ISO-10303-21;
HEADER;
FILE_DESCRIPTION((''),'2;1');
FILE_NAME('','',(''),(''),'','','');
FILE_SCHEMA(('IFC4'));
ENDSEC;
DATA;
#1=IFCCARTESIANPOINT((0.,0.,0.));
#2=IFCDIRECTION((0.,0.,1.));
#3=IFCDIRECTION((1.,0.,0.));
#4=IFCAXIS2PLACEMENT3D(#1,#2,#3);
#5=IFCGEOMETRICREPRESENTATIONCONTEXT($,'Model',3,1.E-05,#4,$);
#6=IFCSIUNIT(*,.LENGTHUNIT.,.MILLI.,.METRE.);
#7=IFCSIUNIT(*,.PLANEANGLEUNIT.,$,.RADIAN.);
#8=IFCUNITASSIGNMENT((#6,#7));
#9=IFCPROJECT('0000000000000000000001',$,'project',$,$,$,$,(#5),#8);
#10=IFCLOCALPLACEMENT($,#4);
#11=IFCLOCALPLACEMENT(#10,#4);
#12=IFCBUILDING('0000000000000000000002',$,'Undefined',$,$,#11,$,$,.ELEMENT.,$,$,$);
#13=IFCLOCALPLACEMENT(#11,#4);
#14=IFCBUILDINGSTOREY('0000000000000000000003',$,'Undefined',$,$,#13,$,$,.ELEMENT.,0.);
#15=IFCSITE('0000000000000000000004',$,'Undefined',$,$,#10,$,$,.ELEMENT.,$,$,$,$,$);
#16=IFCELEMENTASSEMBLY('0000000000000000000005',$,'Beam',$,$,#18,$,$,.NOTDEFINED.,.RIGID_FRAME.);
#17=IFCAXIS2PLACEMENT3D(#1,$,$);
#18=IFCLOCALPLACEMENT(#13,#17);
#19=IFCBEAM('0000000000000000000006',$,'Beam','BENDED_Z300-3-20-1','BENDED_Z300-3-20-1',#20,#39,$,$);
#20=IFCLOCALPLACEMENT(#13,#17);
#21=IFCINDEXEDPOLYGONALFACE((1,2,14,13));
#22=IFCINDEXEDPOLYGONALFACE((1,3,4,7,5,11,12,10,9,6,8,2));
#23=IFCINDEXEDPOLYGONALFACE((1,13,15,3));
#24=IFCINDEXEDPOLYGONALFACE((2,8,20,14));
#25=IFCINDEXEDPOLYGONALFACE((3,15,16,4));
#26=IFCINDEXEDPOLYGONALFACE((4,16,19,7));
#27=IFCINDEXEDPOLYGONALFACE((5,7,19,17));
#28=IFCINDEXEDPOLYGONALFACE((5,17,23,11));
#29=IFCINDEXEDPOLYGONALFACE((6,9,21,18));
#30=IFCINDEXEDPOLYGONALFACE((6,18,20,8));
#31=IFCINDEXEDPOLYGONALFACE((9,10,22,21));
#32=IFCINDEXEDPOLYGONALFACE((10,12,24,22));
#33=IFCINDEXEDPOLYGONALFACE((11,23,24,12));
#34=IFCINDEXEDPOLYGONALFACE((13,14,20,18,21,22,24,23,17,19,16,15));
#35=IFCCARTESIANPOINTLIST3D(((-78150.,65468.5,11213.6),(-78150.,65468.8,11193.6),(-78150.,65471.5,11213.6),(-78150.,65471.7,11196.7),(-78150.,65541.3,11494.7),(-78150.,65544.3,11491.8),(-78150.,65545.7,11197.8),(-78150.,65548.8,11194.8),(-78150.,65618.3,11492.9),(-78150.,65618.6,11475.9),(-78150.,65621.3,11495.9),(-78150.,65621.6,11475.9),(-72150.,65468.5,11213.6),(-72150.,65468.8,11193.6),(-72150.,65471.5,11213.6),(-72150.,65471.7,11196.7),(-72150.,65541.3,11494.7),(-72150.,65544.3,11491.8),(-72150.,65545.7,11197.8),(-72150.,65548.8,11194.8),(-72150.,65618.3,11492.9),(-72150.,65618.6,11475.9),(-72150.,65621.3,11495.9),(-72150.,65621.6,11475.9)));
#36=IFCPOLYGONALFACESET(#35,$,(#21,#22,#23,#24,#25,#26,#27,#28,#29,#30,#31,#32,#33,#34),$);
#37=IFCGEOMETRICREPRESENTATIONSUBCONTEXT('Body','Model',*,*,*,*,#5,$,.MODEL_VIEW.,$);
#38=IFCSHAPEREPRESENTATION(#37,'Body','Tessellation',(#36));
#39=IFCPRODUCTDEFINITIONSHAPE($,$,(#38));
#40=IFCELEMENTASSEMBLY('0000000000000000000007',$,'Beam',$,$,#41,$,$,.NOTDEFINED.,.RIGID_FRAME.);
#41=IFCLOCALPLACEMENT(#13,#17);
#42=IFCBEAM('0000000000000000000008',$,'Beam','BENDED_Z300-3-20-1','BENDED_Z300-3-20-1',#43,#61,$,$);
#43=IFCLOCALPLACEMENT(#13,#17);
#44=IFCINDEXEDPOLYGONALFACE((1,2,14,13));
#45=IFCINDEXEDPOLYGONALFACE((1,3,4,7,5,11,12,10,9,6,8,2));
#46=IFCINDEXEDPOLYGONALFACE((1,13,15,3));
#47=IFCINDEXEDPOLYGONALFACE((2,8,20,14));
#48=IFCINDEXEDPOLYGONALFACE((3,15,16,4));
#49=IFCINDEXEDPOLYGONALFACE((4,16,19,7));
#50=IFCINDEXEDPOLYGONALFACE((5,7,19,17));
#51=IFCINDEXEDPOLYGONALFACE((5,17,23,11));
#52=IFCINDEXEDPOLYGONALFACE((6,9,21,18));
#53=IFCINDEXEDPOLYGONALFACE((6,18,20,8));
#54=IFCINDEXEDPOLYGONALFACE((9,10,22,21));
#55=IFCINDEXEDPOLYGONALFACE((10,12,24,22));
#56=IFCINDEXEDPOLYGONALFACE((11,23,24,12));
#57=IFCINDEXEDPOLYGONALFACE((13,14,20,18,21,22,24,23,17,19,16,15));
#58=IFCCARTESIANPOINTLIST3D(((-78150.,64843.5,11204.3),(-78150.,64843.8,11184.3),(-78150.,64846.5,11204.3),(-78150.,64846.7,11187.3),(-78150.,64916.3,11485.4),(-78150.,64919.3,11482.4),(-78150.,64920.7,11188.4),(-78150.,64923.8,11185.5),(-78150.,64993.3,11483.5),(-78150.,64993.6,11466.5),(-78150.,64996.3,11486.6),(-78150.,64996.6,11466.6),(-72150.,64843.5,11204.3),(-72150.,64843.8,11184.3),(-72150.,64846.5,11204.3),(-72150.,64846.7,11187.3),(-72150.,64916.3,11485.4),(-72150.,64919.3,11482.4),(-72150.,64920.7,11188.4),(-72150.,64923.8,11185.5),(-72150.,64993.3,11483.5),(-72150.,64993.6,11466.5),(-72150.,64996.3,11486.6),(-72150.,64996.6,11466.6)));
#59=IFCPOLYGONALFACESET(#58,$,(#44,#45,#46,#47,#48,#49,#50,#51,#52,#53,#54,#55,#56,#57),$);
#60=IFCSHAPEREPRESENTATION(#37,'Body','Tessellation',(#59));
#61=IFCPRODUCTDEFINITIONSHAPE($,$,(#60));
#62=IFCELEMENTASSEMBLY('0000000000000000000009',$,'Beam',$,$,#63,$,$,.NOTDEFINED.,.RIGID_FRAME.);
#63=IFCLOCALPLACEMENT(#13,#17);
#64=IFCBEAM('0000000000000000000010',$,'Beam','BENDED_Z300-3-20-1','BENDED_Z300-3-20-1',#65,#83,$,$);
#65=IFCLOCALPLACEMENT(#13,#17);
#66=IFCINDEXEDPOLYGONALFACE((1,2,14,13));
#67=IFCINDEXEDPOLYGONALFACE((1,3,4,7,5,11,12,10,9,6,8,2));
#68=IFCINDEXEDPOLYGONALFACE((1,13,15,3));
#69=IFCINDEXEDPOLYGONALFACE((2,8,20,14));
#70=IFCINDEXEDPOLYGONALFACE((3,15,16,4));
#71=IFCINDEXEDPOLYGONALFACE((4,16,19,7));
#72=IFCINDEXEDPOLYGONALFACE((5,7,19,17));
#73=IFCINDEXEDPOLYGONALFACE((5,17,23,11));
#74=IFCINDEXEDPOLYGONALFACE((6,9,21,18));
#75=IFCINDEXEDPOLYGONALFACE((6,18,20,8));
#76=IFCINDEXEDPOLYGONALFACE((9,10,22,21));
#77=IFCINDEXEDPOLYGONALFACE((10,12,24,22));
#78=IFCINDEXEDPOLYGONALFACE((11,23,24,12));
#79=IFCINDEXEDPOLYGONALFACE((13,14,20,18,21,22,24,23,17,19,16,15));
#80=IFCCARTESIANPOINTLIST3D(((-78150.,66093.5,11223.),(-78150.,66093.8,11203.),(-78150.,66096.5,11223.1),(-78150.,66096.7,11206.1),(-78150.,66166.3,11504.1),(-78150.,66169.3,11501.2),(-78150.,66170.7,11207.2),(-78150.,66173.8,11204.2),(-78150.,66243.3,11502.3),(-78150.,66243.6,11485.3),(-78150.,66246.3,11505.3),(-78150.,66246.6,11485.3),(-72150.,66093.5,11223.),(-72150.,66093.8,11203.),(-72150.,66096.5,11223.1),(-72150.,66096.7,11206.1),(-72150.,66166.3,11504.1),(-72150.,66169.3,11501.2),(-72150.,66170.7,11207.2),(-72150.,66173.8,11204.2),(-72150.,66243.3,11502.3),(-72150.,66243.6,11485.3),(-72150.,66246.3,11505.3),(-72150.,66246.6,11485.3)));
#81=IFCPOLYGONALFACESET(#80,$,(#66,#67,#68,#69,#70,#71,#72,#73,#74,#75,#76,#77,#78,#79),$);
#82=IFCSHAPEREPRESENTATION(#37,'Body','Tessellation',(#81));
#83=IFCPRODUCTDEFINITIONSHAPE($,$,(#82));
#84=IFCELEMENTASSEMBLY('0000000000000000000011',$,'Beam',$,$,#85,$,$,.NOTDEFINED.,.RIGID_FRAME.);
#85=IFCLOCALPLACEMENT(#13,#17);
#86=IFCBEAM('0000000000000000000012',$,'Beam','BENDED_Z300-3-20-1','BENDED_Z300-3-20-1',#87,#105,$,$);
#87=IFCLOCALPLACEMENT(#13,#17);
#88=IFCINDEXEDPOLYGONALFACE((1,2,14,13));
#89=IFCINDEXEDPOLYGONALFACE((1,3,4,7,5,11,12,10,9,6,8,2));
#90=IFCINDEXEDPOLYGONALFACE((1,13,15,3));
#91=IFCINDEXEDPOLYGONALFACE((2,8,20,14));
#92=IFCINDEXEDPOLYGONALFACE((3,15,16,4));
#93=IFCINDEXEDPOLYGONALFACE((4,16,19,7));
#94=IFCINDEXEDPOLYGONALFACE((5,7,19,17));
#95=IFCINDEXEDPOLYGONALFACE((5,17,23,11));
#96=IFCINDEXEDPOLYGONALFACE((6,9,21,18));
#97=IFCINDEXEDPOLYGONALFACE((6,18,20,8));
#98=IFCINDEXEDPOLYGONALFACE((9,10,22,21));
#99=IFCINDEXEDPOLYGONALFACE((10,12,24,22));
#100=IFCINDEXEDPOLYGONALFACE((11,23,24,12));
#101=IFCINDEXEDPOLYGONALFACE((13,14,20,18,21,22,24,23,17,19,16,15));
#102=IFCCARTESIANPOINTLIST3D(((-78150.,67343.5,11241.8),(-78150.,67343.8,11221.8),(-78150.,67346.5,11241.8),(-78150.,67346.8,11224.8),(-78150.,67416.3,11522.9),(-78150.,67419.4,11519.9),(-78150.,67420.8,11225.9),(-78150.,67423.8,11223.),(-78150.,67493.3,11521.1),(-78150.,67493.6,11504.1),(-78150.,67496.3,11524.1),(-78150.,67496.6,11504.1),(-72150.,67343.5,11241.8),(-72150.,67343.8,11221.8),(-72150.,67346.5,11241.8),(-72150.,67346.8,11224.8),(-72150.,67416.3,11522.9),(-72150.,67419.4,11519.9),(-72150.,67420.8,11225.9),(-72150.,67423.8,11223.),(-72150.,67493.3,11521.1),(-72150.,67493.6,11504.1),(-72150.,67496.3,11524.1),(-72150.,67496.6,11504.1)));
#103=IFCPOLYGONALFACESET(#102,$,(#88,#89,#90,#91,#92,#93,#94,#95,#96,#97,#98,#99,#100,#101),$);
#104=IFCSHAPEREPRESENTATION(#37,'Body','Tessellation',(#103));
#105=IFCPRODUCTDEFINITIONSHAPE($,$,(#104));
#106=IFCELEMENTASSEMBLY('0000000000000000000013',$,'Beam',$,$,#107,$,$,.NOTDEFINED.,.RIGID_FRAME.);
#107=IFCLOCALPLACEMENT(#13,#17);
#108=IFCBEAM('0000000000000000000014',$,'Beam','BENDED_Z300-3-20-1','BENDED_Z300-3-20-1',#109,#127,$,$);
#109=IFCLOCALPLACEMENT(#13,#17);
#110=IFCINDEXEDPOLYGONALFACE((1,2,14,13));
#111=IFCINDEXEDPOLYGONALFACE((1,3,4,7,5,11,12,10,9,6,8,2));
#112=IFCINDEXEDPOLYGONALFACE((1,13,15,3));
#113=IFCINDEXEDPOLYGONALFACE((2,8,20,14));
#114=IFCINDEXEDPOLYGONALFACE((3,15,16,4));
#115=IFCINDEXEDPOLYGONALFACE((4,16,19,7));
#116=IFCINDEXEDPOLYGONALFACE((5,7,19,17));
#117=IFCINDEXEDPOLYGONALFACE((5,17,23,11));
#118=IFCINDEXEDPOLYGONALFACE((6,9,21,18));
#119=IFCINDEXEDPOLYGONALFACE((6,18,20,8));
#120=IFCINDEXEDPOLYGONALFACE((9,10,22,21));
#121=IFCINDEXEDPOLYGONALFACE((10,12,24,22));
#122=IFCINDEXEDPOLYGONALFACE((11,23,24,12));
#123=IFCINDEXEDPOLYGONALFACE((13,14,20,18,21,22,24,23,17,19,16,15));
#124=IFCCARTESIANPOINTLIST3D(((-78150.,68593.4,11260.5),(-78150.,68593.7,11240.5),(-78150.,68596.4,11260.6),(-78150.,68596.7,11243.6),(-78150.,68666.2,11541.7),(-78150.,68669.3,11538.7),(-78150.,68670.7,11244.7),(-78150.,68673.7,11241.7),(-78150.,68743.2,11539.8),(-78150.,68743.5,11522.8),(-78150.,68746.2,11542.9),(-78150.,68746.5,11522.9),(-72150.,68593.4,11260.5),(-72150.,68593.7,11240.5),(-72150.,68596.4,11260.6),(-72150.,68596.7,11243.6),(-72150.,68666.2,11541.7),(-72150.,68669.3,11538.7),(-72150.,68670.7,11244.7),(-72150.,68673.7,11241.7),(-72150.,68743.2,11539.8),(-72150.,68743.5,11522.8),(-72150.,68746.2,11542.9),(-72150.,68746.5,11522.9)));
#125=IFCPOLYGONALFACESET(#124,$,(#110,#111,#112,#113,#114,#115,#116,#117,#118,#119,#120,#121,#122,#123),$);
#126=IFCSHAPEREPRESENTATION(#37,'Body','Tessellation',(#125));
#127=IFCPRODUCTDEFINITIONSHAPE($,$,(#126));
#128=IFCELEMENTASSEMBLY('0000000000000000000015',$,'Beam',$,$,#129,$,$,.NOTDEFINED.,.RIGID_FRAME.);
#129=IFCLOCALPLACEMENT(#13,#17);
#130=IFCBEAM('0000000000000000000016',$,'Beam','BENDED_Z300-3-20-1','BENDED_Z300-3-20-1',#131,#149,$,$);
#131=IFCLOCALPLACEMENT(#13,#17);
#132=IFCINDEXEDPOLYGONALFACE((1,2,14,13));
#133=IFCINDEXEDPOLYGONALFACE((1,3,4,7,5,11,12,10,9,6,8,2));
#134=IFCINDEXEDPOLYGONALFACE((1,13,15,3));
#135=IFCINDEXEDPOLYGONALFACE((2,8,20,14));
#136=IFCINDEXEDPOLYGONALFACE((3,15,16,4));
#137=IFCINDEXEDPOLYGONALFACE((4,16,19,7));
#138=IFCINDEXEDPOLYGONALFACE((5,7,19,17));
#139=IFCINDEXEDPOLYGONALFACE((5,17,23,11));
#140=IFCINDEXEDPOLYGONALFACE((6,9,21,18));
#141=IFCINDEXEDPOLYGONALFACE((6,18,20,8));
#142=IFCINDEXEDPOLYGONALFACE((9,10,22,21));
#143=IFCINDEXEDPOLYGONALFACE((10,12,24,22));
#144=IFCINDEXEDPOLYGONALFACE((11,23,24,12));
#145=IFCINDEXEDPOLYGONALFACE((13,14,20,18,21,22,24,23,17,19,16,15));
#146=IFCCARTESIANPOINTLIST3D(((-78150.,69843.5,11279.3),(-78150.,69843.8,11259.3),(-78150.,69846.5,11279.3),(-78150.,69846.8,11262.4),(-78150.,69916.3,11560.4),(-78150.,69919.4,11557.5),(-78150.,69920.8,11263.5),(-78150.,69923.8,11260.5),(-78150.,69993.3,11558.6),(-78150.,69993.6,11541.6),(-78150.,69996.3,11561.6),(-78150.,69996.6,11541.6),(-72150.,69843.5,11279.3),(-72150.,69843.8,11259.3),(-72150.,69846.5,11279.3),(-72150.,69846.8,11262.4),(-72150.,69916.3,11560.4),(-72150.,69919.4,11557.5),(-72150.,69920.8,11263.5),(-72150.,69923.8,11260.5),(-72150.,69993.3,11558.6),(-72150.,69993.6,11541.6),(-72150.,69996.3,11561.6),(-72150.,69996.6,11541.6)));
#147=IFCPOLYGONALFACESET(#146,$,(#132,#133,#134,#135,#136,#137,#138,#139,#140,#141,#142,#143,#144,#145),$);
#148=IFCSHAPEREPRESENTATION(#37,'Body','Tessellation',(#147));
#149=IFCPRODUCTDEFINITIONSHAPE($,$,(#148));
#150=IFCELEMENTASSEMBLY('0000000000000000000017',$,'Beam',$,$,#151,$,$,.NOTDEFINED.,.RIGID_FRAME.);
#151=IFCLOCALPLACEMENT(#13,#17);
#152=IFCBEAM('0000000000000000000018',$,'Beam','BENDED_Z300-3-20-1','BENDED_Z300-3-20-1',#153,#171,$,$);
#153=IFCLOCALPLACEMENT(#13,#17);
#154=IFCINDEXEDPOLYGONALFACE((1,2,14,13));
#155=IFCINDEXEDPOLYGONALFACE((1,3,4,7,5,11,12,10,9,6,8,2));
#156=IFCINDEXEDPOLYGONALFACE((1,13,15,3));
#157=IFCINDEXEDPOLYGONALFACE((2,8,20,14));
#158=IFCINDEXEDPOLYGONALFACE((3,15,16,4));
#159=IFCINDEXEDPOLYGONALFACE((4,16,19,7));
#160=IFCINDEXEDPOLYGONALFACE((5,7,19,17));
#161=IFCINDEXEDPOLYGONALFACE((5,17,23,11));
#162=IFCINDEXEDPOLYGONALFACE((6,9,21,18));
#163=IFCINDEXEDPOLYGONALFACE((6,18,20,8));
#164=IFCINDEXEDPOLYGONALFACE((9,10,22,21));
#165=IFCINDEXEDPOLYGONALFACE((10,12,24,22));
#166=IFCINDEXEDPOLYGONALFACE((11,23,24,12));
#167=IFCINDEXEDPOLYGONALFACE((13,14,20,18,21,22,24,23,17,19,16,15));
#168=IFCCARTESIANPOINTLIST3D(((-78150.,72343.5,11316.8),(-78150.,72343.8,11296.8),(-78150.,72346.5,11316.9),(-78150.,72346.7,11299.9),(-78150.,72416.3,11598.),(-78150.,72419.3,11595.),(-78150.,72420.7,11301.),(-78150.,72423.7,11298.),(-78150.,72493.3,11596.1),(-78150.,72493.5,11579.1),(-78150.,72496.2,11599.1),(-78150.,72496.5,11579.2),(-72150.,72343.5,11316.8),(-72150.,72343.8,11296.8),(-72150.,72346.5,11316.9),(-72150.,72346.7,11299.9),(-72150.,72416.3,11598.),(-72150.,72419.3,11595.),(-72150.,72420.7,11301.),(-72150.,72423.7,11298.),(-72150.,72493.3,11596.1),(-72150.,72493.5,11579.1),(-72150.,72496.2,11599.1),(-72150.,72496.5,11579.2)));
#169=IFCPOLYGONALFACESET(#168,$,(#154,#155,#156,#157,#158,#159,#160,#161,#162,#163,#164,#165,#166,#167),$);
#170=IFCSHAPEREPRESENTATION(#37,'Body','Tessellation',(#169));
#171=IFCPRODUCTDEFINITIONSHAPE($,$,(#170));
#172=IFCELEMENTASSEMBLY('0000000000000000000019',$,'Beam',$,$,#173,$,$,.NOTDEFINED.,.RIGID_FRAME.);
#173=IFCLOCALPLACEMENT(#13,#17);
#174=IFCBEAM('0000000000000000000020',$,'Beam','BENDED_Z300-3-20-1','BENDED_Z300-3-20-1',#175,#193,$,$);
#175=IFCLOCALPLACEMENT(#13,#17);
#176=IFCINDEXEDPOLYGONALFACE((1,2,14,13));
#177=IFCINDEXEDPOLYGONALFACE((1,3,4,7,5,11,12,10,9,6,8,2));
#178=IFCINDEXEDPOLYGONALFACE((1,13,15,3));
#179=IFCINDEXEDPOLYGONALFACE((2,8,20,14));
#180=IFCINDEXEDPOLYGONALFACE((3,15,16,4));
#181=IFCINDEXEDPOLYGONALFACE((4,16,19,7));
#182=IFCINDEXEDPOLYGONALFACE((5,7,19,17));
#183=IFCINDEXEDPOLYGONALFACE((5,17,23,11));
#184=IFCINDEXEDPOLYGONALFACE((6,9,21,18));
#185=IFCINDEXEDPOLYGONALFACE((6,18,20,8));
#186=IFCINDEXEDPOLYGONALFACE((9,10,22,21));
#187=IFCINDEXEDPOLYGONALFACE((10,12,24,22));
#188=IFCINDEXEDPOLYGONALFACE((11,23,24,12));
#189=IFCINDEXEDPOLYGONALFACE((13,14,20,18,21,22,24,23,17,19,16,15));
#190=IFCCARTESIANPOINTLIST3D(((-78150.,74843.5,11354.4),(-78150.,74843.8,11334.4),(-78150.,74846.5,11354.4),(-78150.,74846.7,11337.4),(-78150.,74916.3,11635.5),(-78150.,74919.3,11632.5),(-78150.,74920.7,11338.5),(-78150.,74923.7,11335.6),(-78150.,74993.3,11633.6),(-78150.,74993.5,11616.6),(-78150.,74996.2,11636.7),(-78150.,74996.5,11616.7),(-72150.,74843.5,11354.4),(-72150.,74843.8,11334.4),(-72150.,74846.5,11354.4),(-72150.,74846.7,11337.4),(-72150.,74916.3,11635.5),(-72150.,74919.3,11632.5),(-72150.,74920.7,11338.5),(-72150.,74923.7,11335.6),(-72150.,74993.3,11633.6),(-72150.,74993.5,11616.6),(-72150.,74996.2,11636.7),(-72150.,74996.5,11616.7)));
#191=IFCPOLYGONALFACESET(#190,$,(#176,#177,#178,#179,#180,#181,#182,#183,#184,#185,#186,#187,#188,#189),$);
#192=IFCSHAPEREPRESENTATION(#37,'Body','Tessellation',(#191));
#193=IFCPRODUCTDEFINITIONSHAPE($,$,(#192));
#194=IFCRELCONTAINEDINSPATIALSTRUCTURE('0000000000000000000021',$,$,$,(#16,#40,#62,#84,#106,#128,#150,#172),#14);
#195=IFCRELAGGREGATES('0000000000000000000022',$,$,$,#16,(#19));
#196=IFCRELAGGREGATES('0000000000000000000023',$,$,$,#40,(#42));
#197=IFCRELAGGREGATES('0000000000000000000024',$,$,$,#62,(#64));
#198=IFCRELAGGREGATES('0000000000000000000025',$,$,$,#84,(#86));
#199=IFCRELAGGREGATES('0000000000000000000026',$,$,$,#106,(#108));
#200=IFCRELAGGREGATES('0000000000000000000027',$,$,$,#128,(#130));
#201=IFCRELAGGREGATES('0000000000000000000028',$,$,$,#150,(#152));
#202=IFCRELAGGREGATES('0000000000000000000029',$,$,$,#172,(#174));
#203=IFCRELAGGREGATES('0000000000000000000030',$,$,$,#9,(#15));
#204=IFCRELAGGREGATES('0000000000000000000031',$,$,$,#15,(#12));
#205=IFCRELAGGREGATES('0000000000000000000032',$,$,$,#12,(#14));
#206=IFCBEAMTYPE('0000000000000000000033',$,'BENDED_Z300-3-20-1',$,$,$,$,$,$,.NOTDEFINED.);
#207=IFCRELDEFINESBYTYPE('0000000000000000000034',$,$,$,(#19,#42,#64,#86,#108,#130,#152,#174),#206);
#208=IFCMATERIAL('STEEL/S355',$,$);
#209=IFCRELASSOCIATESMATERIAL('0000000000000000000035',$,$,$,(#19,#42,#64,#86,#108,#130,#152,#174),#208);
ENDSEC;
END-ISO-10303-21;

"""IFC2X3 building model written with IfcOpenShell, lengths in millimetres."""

from ifc_helpers import new_model, si_unit, frame, origin_with_axes, place, context, subcontext, project, spatial, polyline, outline, extrude, material, type_object, element, aggregate, save


model = new_model("IFC2X3")

# Units and contexts
model_context = context("Model", 3, precision=1e-05, world=origin_with_axes())
body_context = subcontext(model_context, "Body", "Model", "MODEL_VIEW")
ifc_project = project(units=[si_unit("LENGTHUNIT", "METRE", prefix="MILLI"), si_unit("PLANEANGLEUNIT", "RADIAN")], contexts=[model_context])

# Site, building, storey
site_placement = place(None, origin_with_axes())
site = spatial("IfcSite", under=ifc_project, at=site_placement, Name="Undefined", CompositionType="ELEMENT")
building_placement = place(site_placement, origin_with_axes())
building = spatial("IfcBuilding", under=site, at=building_placement, Name="Undefined", CompositionType="ELEMENT")
storey_placement = place(building_placement, origin_with_axes())
storey = spatial("IfcBuildingStorey", under=building, at=storey_placement, Name="Undefined", CompositionType="ELEMENT", Elevation=0.0)

# Element assemblies, beams
ifc_material = material(Name="STEEL/S355")
beam_type_1 = type_object("IfcBeamType", Name="BENDED_Z300-3-20-1", PredefinedType="NOTDEFINED")
assembly_1_placement = place(storey_placement, origin_with_axes())
assembly_1 = element("IfcElementAssembly", 1, at=assembly_1_placement, inside=storey, Name="Beam", AssemblyPlace="NOTDEFINED", PredefinedType="RIGID_FRAME")
beam_1_placement = place(assembly_1_placement, frame((-72150.0, 65545.0, 11344.8), z_axis=(0.0, -0.014963, 0.999888), x_axis=(-1.0, 0.0, 0.0)))
beam_1 = element("IfcBeam", 2, at=beam_1_placement, type_object=beam_type_1, material=ifc_material, Name="Beam", Description="BENDED_Z300-3-20-1", ObjectType="BENDED_Z300-3-20-1", context=body_context, shape_type="SweptSolid", body=[
    extrude(outline(polyline([(1.5, -150.0), (-78.5, -150.0), (-78.5, -130.0), (-75.5, -130.0), (-75.5, -147.0), (-1.5, -147.0), (-1.5, 150.0), (78.5, 150.0), (78.5, 130.0), (75.5, 130.0), (75.5, 147.0), (1.5, 147.0), (1.5, -150.0)])), frame((6000.0, 0.0, 0.0), z_axis=(-1.0, 0.0, 0.0), x_axis=(0.0, -1.0, 0.0)), (0.0, 0.0, 1.0), 6000.0),
])
aggregate(assembly_1, [beam_1])
assembly_2_placement = place(storey_placement, origin_with_axes())
assembly_2 = element("IfcElementAssembly", 3, at=assembly_2_placement, inside=storey, Name="Beam", AssemblyPlace="NOTDEFINED", PredefinedType="RIGID_FRAME")
beam_2_placement = place(assembly_2_placement, frame((-72150.0, 64920.0, 11335.4), z_axis=(0.0, -0.014963, 0.999888), x_axis=(-1.0, 0.0, 0.0)))
beam_2 = element("IfcBeam", 4, at=beam_2_placement, type_object=beam_type_1, material=ifc_material, Name="Beam", Description="BENDED_Z300-3-20-1", ObjectType="BENDED_Z300-3-20-1", context=body_context, shape_type="SweptSolid", body=[
    extrude(outline(polyline([(1.5, -150.0), (-78.5, -150.0), (-78.5, -130.0), (-75.5, -130.0), (-75.5, -147.0), (-1.5, -147.0), (-1.5, 150.0), (78.5, 150.0), (78.5, 130.0), (75.5, 130.0), (75.5, 147.0), (1.5, 147.0), (1.5, -150.0)])), frame((6000.0, 0.0, 0.0), z_axis=(-1.0, 0.0, 0.0), x_axis=(0.0, -1.0, 0.0)), (0.0, 0.0, 1.0), 6000.0),
])
aggregate(assembly_2, [beam_2])
assembly_3_placement = place(storey_placement, origin_with_axes())
assembly_3 = element("IfcElementAssembly", 5, at=assembly_3_placement, inside=storey, Name="Beam", AssemblyPlace="NOTDEFINED", PredefinedType="RIGID_FRAME")
beam_3_placement = place(assembly_3_placement, frame((-72150.0, 66170.0, 11354.2), z_axis=(0.0, -0.014963, 0.999888), x_axis=(-1.0, 0.0, 0.0)))
beam_3 = element("IfcBeam", 6, at=beam_3_placement, type_object=beam_type_1, material=ifc_material, Name="Beam", Description="BENDED_Z300-3-20-1", ObjectType="BENDED_Z300-3-20-1", context=body_context, shape_type="SweptSolid", body=[
    extrude(outline(polyline([(1.5, -150.0), (-78.5, -150.0), (-78.5, -130.0), (-75.5, -130.0), (-75.5, -147.0), (-1.5, -147.0), (-1.5, 150.0), (78.5, 150.0), (78.5, 130.0), (75.5, 130.0), (75.5, 147.0), (1.5, 147.0), (1.5, -150.0)])), frame((6000.0, 0.0, 0.0), z_axis=(-1.0, 0.0, 0.0), x_axis=(0.0, -1.0, 0.0)), (0.0, 0.0, 1.0), 6000.0),
])
aggregate(assembly_3, [beam_3])
assembly_4_placement = place(storey_placement, origin_with_axes())
assembly_4 = element("IfcElementAssembly", 7, at=assembly_4_placement, inside=storey, Name="Beam", AssemblyPlace="NOTDEFINED", PredefinedType="RIGID_FRAME")
beam_4_placement = place(assembly_4_placement, frame((-72150.0, 67420.1, 11372.9), z_axis=(0.0, -0.014963, 0.999888), x_axis=(-1.0, 0.0, 0.0)))
beam_4 = element("IfcBeam", 8, at=beam_4_placement, type_object=beam_type_1, material=ifc_material, Name="Beam", Description="BENDED_Z300-3-20-1", ObjectType="BENDED_Z300-3-20-1", context=body_context, shape_type="SweptSolid", body=[
    extrude(outline(polyline([(1.5, -150.0), (-78.5, -150.0), (-78.5, -130.0), (-75.5, -130.0), (-75.5, -147.0), (-1.5, -147.0), (-1.5, 150.0), (78.5, 150.0), (78.5, 130.0), (75.5, 130.0), (75.5, 147.0), (1.5, 147.0), (1.5, -150.0)])), frame((6000.0, 0.0, 0.0), z_axis=(-1.0, 0.0, 0.0), x_axis=(0.0, -1.0, 0.0)), (0.0, 0.0, 1.0), 6000.0),
])
aggregate(assembly_4, [beam_4])
assembly_5_placement = place(storey_placement, origin_with_axes())
assembly_5 = element("IfcElementAssembly", 9, at=assembly_5_placement, inside=storey, Name="Beam", AssemblyPlace="NOTDEFINED", PredefinedType="RIGID_FRAME")
beam_5_placement = place(assembly_5_placement, frame((-72150.0, 68670.0, 11391.7), z_axis=(0.0, -0.014963, 0.999888), x_axis=(-1.0, 0.0, 0.0)))
beam_5 = element("IfcBeam", 10, at=beam_5_placement, type_object=beam_type_1, material=ifc_material, Name="Beam", Description="BENDED_Z300-3-20-1", ObjectType="BENDED_Z300-3-20-1", context=body_context, shape_type="SweptSolid", body=[
    extrude(outline(polyline([(1.5, -150.0), (-78.5, -150.0), (-78.5, -130.0), (-75.5, -130.0), (-75.5, -147.0), (-1.5, -147.0), (-1.5, 150.0), (78.5, 150.0), (78.5, 130.0), (75.5, 130.0), (75.5, 147.0), (1.5, 147.0), (1.5, -150.0)])), frame((6000.0, 0.0, 0.0), z_axis=(-1.0, 0.0, 0.0), x_axis=(0.0, -1.0, 0.0)), (0.0, 0.0, 1.0), 6000.0),
])
aggregate(assembly_5, [beam_5])
assembly_6_placement = place(storey_placement, origin_with_axes())
assembly_6 = element("IfcElementAssembly", 11, at=assembly_6_placement, inside=storey, Name="Beam", AssemblyPlace="NOTDEFINED", PredefinedType="RIGID_FRAME")
beam_6_placement = place(assembly_6_placement, frame((-72150.0, 69920.1, 11410.5), z_axis=(0.0, -0.014963, 0.999888), x_axis=(-1.0, 0.0, 0.0)))
beam_6 = element("IfcBeam", 12, at=beam_6_placement, type_object=beam_type_1, material=ifc_material, Name="Beam", Description="BENDED_Z300-3-20-1", ObjectType="BENDED_Z300-3-20-1", context=body_context, shape_type="SweptSolid", body=[
    extrude(outline(polyline([(1.5, -150.0), (-78.5, -150.0), (-78.5, -130.0), (-75.5, -130.0), (-75.5, -147.0), (-1.5, -147.0), (-1.5, 150.0), (78.5, 150.0), (78.5, 130.0), (75.5, 130.0), (75.5, 147.0), (1.5, 147.0), (1.5, -150.0)])), frame((6000.0, 0.0, 0.0), z_axis=(-1.0, 0.0, 0.0), x_axis=(0.0, -1.0, 0.0)), (0.0, 0.0, 1.0), 6000.0),
])
aggregate(assembly_6, [beam_6])
assembly_7_placement = place(storey_placement, origin_with_axes())
assembly_7 = element("IfcElementAssembly", 13, at=assembly_7_placement, inside=storey, Name="Beam", AssemblyPlace="NOTDEFINED", PredefinedType="RIGID_FRAME")
beam_7_placement = place(assembly_7_placement, frame((-72150.0, 72420.0, 11448.0), z_axis=(0.0, -0.014963, 0.999888), x_axis=(-1.0, 0.0, 0.0)))
beam_7 = element("IfcBeam", 14, at=beam_7_placement, type_object=beam_type_1, material=ifc_material, Name="Beam", Description="BENDED_Z300-3-20-1", ObjectType="BENDED_Z300-3-20-1", context=body_context, shape_type="SweptSolid", body=[
    extrude(outline(polyline([(1.5, -150.0), (-78.5, -150.0), (-78.5, -130.0), (-75.5, -130.0), (-75.5, -147.0), (-1.5, -147.0), (-1.5, 150.0), (78.5, 150.0), (78.5, 130.0), (75.5, 130.0), (75.5, 147.0), (1.5, 147.0), (1.5, -150.0)])), frame((6000.0, 0.0, 0.0), z_axis=(-1.0, 0.0, 0.0), x_axis=(0.0, -1.0, 0.0)), (0.0, 0.0, 1.0), 6000.0),
])
aggregate(assembly_7, [beam_7])
assembly_8_placement = place(storey_placement, origin_with_axes())
assembly_8 = element("IfcElementAssembly", 15, at=assembly_8_placement, inside=storey, Name="Beam", AssemblyPlace="NOTDEFINED", PredefinedType="RIGID_FRAME")
beam_8_placement = place(assembly_8_placement, frame((-72150.0, 74920.0, 11485.5), z_axis=(0.0, -0.014963, 0.999888), x_axis=(-1.0, 0.0, 0.0)))
beam_8 = element("IfcBeam", 16, at=beam_8_placement, type_object=beam_type_1, material=ifc_material, Name="Beam", Description="BENDED_Z300-3-20-1", ObjectType="BENDED_Z300-3-20-1", context=body_context, shape_type="SweptSolid", body=[
    extrude(outline(polyline([(1.5, -150.0), (-78.5, -150.0), (-78.5, -130.0), (-75.5, -130.0), (-75.5, -147.0), (-1.5, -147.0), (-1.5, 150.0), (78.5, 150.0), (78.5, 130.0), (75.5, 130.0), (75.5, 147.0), (1.5, 147.0), (1.5, -150.0)])), frame((6000.0, 0.0, 0.0), z_axis=(-1.0, 0.0, 0.0), x_axis=(0.0, -1.0, 0.0)), (0.0, 0.0, 1.0), 6000.0),
])
aggregate(assembly_8, [beam_8])

save(model, "model.ifc")
